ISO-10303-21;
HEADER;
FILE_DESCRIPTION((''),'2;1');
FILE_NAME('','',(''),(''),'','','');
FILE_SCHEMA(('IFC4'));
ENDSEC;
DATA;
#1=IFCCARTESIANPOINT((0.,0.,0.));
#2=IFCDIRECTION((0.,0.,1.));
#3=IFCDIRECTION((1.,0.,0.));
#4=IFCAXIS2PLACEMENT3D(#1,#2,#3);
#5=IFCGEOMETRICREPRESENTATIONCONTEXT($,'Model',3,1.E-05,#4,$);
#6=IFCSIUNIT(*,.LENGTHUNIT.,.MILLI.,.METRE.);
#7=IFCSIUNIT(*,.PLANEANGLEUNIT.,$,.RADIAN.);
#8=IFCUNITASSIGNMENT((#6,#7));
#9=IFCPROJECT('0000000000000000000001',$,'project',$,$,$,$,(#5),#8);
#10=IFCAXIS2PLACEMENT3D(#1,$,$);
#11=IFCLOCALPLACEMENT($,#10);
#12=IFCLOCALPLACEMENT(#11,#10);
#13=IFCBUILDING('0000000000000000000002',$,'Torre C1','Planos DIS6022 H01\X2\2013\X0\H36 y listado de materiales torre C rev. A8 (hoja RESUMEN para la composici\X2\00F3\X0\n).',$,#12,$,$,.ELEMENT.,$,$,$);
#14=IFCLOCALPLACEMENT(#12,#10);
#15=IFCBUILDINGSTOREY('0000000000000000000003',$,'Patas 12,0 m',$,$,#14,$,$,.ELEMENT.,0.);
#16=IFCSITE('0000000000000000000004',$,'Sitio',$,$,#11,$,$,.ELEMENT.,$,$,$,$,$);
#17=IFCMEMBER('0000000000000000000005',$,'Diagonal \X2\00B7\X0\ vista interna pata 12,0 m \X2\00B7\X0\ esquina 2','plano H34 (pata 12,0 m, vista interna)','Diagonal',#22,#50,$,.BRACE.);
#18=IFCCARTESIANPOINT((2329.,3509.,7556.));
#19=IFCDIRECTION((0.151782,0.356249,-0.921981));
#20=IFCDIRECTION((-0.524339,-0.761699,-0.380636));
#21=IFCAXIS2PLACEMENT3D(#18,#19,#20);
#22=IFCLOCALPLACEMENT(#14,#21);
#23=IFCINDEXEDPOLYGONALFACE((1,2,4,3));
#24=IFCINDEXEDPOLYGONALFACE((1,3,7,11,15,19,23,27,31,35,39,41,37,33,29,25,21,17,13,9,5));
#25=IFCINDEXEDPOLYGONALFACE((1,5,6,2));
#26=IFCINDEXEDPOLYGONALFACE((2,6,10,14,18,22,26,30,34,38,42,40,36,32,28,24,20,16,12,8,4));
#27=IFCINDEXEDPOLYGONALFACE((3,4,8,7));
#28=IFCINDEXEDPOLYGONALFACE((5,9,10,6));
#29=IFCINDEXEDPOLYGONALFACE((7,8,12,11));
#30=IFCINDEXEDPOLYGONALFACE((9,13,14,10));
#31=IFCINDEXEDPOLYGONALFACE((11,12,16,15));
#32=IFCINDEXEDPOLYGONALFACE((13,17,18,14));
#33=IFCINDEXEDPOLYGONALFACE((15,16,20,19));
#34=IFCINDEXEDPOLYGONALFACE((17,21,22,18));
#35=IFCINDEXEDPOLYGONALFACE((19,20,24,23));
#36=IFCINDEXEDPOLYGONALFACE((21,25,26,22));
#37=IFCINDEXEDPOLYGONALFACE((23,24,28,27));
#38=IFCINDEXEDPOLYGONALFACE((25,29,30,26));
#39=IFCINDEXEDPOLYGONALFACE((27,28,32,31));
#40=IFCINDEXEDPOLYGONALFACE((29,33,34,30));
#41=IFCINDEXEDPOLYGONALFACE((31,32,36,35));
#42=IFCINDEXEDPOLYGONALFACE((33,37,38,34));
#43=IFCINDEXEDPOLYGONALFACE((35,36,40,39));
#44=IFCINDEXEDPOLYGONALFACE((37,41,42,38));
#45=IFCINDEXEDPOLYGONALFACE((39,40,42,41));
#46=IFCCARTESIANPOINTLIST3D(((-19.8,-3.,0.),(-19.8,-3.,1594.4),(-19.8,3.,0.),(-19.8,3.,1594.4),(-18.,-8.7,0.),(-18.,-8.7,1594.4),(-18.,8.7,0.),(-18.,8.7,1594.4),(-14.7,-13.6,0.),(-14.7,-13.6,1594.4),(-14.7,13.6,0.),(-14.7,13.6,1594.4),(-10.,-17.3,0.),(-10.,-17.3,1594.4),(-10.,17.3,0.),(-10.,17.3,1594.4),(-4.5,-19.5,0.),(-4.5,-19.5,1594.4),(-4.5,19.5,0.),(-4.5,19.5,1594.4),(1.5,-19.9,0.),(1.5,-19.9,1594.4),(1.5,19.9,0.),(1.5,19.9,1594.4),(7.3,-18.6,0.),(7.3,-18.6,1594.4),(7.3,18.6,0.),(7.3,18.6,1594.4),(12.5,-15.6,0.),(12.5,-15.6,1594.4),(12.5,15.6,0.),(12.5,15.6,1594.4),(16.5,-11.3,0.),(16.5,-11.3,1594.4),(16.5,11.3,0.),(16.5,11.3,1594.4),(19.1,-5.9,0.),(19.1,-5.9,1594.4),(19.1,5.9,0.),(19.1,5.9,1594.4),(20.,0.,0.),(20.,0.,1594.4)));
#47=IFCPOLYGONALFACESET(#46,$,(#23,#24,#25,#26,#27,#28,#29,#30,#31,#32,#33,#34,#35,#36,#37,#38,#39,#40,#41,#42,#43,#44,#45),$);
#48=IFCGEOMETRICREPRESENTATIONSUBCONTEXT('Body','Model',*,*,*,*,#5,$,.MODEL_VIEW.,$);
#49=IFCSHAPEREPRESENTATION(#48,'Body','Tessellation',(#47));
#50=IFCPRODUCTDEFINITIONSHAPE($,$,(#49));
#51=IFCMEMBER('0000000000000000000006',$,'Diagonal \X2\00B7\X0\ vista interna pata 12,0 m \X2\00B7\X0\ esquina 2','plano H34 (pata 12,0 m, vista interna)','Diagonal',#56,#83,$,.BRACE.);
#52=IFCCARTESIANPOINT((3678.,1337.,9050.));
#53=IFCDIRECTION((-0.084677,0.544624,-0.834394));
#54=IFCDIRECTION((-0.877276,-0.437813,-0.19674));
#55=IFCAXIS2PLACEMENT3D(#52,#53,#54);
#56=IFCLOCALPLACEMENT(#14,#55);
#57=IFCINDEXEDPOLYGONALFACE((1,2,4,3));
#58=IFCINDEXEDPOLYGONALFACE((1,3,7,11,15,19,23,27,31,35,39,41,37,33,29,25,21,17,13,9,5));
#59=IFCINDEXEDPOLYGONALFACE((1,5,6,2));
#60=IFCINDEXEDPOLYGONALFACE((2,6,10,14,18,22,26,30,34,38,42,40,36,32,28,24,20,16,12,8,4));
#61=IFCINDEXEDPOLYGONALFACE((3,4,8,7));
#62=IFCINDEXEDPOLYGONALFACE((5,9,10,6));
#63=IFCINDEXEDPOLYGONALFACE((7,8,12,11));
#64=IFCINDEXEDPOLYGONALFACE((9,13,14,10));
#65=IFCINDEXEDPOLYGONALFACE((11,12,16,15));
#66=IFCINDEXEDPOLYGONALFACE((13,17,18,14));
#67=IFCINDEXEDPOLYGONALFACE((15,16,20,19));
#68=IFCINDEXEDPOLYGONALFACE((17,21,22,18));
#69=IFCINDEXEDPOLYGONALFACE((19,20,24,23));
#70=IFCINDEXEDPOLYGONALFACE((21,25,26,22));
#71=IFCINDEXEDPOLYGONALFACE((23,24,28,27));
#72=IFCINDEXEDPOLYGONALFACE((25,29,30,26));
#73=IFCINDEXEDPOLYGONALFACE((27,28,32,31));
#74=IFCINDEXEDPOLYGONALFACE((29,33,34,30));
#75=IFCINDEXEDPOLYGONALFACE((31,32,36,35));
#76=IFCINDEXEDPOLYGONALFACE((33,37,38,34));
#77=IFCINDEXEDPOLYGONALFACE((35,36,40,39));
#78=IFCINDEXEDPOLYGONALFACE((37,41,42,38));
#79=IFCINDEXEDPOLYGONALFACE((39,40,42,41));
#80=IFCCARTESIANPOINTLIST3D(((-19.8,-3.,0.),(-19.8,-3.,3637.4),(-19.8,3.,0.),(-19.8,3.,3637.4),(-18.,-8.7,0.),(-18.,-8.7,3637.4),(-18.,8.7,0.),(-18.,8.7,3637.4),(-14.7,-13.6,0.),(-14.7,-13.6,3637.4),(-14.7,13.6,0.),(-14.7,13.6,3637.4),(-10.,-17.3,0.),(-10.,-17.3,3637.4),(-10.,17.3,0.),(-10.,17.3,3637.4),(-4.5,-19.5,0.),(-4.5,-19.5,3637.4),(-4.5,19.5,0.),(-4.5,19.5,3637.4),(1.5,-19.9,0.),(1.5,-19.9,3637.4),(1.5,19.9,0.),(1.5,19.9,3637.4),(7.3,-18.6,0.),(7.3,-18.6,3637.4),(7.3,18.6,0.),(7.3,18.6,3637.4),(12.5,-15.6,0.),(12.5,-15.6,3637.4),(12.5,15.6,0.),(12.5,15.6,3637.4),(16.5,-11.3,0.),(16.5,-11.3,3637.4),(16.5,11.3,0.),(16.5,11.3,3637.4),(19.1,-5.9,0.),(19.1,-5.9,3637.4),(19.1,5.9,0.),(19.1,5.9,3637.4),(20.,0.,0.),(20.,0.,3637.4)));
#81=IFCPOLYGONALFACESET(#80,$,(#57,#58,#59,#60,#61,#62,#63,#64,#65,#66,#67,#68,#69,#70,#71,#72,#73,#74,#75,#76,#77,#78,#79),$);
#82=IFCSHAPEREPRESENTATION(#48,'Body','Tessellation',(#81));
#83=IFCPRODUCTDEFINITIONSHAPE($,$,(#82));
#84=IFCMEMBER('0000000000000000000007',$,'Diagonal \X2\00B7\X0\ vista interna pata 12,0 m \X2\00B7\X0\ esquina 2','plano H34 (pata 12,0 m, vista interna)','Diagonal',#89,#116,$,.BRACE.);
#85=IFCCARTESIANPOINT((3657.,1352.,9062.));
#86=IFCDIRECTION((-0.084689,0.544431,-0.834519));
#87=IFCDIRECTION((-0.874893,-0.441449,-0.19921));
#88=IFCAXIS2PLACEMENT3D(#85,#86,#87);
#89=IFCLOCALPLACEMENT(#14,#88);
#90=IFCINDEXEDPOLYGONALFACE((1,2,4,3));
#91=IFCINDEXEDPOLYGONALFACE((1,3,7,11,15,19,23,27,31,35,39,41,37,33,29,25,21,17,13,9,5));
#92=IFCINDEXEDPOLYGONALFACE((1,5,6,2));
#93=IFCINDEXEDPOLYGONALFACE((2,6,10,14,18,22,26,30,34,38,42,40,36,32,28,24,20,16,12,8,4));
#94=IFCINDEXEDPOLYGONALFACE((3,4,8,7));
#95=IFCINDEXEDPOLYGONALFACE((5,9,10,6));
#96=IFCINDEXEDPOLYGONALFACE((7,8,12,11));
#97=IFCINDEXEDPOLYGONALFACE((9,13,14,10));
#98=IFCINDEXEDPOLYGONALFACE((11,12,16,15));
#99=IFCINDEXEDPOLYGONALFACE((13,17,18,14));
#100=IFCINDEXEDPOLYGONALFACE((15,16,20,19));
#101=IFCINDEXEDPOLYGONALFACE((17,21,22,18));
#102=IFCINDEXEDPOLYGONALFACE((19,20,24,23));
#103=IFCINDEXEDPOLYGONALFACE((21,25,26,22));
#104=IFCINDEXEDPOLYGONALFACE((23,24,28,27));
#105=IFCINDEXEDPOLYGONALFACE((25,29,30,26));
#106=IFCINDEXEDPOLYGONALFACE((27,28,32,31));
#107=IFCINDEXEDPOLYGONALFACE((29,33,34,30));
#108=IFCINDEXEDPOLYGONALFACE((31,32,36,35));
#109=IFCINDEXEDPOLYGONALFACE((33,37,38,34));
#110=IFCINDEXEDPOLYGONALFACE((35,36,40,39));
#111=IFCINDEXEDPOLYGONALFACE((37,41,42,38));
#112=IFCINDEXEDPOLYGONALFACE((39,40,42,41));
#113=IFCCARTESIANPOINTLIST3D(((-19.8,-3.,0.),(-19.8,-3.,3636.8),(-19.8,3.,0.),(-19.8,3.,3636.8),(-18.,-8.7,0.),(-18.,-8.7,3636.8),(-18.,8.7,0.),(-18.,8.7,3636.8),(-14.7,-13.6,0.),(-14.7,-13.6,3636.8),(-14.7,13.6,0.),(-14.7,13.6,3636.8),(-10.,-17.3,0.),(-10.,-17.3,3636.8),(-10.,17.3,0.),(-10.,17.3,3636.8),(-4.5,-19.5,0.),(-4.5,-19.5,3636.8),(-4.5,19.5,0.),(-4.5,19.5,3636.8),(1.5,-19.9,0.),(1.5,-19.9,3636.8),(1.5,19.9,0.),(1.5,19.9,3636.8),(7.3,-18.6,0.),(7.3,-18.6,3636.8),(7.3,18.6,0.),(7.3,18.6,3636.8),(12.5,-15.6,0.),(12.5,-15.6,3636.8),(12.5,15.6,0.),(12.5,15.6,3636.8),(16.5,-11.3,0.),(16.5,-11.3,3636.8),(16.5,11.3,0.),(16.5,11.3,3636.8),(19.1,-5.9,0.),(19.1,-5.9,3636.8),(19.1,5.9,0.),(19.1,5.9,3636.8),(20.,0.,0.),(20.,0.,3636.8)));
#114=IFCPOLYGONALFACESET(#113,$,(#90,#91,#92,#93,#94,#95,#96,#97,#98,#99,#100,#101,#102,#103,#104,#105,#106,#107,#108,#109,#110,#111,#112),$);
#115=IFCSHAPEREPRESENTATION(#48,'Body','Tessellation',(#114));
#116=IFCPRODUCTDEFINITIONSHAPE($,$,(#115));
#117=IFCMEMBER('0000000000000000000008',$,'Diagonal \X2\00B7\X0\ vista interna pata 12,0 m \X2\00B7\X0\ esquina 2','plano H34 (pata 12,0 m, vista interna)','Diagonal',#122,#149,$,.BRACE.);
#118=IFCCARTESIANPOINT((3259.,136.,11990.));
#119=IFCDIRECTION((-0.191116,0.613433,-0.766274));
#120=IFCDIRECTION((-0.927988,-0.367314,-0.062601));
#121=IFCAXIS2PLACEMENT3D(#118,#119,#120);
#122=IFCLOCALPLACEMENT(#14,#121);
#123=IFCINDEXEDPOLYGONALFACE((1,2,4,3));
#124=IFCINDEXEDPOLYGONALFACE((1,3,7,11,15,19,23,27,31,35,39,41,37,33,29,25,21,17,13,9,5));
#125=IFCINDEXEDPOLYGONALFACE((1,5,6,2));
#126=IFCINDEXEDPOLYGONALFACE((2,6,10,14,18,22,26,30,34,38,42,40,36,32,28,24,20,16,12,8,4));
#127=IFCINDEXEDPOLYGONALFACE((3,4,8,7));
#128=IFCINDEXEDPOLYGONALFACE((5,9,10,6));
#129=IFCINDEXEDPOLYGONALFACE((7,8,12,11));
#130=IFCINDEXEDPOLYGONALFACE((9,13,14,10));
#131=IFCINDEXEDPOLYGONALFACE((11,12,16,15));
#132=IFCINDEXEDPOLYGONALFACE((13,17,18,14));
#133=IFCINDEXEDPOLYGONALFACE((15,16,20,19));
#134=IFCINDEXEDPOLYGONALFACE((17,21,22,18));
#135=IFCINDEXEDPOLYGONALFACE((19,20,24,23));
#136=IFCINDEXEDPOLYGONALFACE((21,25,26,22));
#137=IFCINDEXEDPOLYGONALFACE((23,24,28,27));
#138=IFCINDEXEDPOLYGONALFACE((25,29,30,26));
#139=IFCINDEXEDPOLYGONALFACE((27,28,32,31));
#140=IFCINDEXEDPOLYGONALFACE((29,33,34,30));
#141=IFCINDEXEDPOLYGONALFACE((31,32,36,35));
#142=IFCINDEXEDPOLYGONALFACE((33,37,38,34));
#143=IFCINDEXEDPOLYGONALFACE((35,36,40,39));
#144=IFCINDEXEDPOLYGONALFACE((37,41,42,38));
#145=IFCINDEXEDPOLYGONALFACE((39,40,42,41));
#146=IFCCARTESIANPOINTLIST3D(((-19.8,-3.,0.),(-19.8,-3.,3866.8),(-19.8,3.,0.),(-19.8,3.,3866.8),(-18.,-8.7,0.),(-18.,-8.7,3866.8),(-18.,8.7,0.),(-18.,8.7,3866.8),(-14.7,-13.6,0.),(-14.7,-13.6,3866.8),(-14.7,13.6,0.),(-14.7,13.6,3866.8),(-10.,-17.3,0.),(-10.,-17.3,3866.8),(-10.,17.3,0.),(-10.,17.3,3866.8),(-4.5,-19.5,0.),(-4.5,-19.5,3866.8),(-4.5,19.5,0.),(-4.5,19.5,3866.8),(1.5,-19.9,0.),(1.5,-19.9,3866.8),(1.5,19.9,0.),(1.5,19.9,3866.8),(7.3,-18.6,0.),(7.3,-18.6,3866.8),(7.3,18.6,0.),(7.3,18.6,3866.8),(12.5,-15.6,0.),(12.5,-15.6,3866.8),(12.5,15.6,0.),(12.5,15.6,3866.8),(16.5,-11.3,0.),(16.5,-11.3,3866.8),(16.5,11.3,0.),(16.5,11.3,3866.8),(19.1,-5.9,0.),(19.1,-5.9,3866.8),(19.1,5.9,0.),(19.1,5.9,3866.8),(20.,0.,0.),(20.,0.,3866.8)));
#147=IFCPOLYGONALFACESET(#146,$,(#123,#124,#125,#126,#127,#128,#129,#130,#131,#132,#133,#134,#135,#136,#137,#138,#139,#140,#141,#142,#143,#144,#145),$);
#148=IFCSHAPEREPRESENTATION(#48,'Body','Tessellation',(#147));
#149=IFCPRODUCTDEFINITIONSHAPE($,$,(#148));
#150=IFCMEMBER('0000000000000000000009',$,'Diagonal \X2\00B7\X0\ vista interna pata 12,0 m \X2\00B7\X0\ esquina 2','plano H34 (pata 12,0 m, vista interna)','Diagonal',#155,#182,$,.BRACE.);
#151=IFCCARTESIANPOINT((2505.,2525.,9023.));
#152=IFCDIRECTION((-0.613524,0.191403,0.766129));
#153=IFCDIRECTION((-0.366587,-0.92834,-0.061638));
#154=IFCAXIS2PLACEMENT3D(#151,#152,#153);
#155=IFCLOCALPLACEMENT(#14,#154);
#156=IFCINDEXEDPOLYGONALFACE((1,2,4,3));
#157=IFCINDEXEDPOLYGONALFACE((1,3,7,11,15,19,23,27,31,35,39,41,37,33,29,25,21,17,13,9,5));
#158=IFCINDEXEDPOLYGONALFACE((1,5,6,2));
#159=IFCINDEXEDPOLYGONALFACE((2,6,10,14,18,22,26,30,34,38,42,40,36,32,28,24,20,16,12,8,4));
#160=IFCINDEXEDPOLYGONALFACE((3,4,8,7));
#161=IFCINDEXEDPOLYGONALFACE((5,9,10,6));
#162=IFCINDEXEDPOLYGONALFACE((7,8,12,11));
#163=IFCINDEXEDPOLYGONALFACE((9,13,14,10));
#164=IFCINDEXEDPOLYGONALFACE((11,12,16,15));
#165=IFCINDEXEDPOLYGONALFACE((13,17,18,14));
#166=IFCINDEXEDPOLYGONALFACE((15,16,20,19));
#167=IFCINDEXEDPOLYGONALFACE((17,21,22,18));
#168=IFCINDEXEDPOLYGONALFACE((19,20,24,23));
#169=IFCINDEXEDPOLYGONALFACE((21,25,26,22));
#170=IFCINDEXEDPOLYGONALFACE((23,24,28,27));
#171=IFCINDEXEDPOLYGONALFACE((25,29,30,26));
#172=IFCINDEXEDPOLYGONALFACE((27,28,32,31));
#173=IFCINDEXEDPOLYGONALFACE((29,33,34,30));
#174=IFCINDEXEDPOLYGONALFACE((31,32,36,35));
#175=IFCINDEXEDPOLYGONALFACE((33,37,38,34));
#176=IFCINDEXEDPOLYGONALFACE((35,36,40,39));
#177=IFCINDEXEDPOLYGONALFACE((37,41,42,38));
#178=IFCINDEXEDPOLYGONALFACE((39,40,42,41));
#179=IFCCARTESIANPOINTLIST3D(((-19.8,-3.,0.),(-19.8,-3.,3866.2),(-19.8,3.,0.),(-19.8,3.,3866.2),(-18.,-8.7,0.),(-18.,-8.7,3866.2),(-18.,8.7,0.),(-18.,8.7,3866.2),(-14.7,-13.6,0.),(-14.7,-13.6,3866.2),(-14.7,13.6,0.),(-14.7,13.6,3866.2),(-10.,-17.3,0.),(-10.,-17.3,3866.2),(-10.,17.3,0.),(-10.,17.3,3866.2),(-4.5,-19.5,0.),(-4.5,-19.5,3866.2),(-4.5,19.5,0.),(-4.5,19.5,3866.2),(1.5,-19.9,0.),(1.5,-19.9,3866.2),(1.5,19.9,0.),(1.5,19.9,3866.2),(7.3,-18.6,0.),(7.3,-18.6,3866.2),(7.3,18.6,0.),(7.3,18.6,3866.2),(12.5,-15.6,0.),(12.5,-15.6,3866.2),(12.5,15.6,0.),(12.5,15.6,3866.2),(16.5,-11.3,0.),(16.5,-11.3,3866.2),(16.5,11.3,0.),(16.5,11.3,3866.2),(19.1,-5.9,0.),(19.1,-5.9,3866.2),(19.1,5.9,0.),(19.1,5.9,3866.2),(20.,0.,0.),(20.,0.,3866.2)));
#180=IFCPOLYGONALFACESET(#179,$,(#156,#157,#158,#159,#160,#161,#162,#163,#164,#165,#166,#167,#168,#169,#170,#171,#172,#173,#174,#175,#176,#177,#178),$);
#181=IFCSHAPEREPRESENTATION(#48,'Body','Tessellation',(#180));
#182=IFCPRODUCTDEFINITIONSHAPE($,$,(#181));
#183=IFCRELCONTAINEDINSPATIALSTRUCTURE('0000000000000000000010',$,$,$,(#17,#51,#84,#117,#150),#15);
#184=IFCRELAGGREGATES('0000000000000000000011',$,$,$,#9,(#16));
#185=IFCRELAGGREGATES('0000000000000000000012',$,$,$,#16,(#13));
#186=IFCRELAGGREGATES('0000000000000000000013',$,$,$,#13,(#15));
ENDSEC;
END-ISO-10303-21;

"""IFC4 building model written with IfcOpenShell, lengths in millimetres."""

from ifc_helpers import new_model, si_unit, frame, origin, origin_with_axes, place, context, subcontext, project, spatial, circle, extrude, element, save


model = new_model("IFC4")

# Units and contexts
model_context = context("Model", 3, precision=1e-05, world=origin_with_axes())
body_context = subcontext(model_context, "Body", "Model", "MODEL_VIEW")
ifc_project = project(units=[si_unit("LENGTHUNIT", "METRE", prefix="MILLI"), si_unit("PLANEANGLEUNIT", "RADIAN")], contexts=[model_context])

# Site, building, storey
site_placement = place(None, origin())
site = spatial("IfcSite", under=ifc_project, at=site_placement, Name="Sitio", CompositionType="ELEMENT")
building_placement = place(site_placement, origin())
building = spatial("IfcBuilding", under=site, at=building_placement, Name="Torre C1", Description="Planos DIS6022 H01–H36 y listado de materiales torre C rev. A8 (hoja RESUMEN para la composición).", CompositionType="ELEMENT")
storey_placement = place(building_placement, origin())
storey = spatial("IfcBuildingStorey", under=building, at=storey_placement, Name="Patas 12,0 m", CompositionType="ELEMENT", Elevation=0.0)

# Members
member_1_placement = place(storey_placement, frame((2329.0, 3509.0, 7556.0), z_axis=(0.151782, 0.356249, -0.921981), x_axis=(-0.524339, -0.761699, -0.380636)))
element("IfcMember", 1, at=member_1_placement, inside=storey, Name="Diagonal · vista interna pata 12,0 m · esquina 2", Description="plano H34 (pata 12,0 m, vista interna)", ObjectType="Diagonal", PredefinedType="BRACE", context=body_context, shape_type="SweptSolid", body=[
    extrude(circle(Radius=20.0), None, (0.0, 0.0, 1.0), 1594.4),
])
member_2_placement = place(storey_placement, frame((3678.0, 1337.0, 9050.0), z_axis=(-0.084677, 0.544624, -0.834394), x_axis=(-0.877276, -0.437813, -0.19674)))
element("IfcMember", 2, at=member_2_placement, inside=storey, Name="Diagonal · vista interna pata 12,0 m · esquina 2", Description="plano H34 (pata 12,0 m, vista interna)", ObjectType="Diagonal", PredefinedType="BRACE", context=body_context, shape_type="SweptSolid", body=[
    extrude(circle(Radius=20.0), None, (0.0, 0.0, 1.0), 3637.4),
])
member_3_placement = place(storey_placement, frame((3657.0, 1352.0, 9062.0), z_axis=(-0.084689, 0.544431, -0.834519), x_axis=(-0.874893, -0.441449, -0.19921)))
element("IfcMember", 3, at=member_3_placement, inside=storey, Name="Diagonal · vista interna pata 12,0 m · esquina 2", Description="plano H34 (pata 12,0 m, vista interna)", ObjectType="Diagonal", PredefinedType="BRACE", context=body_context, shape_type="SweptSolid", body=[
    extrude(circle(Radius=20.0), None, (0.0, 0.0, 1.0), 3636.8),
])
member_4_placement = place(storey_placement, frame((3259.0, 136.0, 11990.0), z_axis=(-0.191116, 0.613433, -0.766274), x_axis=(-0.927988, -0.367314, -0.062601)))
element("IfcMember", 4, at=member_4_placement, inside=storey, Name="Diagonal · vista interna pata 12,0 m · esquina 2", Description="plano H34 (pata 12,0 m, vista interna)", ObjectType="Diagonal", PredefinedType="BRACE", context=body_context, shape_type="SweptSolid", body=[
    extrude(circle(Radius=20.0), None, (0.0, 0.0, 1.0), 3866.8),
])
member_5_placement = place(storey_placement, frame((2505.0, 2525.0, 9023.0), z_axis=(-0.613524, 0.191403, 0.766129), x_axis=(-0.366587, -0.92834, -0.061638)))
element("IfcMember", 5, at=member_5_placement, inside=storey, Name="Diagonal · vista interna pata 12,0 m · esquina 2", Description="plano H34 (pata 12,0 m, vista interna)", ObjectType="Diagonal", PredefinedType="BRACE", context=body_context, shape_type="SweptSolid", body=[
    extrude(circle(Radius=20.0), None, (0.0, 0.0, 1.0), 3866.2),
])

save(model, "model.ifc")
